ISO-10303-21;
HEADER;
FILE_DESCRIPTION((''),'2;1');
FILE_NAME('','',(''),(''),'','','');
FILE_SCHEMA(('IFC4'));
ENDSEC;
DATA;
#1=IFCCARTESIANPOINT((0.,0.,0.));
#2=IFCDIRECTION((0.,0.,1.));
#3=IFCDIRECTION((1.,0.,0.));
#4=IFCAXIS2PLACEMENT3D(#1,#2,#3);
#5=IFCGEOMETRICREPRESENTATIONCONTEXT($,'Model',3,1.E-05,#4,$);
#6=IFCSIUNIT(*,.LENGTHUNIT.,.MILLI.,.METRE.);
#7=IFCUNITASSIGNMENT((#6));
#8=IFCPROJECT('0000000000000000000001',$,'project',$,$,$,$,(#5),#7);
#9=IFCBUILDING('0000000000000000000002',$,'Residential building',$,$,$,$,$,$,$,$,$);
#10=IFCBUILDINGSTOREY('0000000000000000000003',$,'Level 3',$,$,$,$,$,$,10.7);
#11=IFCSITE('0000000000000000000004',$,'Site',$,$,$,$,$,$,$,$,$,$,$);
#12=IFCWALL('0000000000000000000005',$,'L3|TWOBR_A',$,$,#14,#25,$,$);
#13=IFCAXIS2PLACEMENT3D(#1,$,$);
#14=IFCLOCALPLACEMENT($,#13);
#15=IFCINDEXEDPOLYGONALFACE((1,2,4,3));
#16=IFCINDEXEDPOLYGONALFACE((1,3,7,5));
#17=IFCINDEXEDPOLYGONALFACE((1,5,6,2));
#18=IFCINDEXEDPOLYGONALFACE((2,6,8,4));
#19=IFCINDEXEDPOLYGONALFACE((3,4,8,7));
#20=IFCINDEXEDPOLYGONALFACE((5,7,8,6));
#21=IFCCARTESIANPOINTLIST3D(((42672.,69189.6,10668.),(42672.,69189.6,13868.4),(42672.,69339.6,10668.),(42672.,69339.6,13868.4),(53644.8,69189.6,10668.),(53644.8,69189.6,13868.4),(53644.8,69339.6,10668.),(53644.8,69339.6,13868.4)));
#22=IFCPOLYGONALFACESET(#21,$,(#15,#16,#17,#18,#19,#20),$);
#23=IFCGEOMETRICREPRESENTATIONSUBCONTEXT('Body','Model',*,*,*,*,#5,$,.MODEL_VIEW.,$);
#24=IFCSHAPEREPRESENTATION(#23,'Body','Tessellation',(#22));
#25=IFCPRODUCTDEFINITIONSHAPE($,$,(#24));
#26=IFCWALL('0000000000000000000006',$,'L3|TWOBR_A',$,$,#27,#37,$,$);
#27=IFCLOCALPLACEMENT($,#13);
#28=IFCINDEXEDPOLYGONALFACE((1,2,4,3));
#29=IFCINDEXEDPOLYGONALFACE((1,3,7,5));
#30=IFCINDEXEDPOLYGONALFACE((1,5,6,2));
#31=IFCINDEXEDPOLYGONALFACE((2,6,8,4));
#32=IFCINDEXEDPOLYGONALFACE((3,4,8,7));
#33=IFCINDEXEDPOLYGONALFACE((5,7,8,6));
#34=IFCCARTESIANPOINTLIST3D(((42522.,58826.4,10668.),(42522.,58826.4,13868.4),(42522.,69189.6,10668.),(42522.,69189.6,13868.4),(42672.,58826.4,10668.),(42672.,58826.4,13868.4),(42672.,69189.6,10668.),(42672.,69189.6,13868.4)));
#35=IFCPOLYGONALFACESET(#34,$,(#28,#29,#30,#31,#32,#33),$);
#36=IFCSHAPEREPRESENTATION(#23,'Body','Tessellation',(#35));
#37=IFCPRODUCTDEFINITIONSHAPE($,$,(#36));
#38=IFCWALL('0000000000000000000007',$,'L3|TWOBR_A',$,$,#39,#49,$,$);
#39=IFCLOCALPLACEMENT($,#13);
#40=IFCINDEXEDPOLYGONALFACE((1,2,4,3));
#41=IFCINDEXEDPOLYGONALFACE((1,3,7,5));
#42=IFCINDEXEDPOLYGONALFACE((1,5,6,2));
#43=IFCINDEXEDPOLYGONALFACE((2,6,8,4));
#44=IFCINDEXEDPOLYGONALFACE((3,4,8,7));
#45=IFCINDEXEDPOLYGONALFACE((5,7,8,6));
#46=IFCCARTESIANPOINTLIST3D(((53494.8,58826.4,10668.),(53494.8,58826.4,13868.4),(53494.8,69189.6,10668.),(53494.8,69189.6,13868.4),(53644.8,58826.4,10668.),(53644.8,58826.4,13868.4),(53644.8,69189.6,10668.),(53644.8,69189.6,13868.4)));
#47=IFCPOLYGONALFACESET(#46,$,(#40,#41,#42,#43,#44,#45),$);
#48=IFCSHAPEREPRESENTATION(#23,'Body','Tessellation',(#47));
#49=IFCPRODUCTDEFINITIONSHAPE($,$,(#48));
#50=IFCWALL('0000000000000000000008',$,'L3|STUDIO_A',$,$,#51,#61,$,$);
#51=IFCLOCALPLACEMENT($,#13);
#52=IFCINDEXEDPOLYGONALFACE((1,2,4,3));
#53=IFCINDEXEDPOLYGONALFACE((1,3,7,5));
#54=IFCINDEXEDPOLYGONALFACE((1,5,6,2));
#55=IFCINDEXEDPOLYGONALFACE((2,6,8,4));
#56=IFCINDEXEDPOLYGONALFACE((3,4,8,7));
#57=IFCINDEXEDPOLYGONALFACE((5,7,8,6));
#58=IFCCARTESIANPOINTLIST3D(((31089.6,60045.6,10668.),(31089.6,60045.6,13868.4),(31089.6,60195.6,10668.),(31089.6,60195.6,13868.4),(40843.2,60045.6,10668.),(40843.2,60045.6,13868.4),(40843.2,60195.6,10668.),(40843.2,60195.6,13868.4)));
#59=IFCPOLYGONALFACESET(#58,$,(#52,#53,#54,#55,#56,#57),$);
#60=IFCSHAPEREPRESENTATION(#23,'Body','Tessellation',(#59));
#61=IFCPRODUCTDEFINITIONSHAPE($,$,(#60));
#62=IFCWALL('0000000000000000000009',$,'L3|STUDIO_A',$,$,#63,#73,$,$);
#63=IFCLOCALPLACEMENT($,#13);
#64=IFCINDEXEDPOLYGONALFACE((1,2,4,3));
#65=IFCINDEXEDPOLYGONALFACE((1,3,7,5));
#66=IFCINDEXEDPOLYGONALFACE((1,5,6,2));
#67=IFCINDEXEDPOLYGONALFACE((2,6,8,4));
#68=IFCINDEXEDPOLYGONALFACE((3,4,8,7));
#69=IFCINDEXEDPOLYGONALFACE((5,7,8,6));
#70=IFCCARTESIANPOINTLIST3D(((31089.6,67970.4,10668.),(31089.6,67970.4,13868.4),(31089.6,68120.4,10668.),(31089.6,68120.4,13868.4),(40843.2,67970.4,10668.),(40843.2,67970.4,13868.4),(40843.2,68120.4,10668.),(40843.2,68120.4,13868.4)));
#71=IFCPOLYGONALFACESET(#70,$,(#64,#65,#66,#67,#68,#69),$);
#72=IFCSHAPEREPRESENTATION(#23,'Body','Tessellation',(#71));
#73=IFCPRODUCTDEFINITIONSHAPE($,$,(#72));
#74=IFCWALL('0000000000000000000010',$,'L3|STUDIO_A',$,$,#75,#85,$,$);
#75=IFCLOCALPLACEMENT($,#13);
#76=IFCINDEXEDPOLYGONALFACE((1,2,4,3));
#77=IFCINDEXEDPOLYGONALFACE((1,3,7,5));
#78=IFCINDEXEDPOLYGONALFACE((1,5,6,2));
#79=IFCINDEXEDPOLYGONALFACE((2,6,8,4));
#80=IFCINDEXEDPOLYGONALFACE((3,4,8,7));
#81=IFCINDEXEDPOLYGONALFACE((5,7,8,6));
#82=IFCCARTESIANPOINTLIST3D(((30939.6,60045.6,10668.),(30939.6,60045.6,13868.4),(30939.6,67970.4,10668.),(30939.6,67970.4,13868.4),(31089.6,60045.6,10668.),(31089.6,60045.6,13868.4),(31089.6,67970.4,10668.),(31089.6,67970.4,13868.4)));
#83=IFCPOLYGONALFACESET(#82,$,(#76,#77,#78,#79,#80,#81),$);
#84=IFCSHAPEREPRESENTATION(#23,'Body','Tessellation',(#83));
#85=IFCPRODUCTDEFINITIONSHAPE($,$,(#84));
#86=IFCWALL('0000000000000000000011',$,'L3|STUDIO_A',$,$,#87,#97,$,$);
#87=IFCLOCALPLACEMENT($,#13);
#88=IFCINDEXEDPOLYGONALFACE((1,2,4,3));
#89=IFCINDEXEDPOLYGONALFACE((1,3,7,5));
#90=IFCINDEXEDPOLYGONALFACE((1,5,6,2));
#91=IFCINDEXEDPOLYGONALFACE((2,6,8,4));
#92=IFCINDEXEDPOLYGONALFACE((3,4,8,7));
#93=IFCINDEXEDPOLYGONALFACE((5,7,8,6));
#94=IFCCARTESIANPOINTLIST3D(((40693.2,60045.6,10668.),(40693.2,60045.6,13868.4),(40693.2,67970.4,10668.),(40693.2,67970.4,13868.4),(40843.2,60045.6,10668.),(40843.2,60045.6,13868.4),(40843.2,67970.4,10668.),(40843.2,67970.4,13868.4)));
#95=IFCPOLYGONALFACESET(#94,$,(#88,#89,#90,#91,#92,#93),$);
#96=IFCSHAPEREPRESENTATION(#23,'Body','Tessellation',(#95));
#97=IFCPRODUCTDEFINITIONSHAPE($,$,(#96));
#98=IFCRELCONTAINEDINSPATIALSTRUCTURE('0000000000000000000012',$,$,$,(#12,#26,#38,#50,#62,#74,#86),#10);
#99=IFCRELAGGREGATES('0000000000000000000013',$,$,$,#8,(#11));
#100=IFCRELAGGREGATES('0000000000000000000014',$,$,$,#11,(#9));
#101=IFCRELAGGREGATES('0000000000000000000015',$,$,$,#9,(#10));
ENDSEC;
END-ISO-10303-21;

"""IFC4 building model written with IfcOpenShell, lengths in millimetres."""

from ifc_helpers import new_model, si_unit, frame, origin_with_axes, place, context, subcontext, project, spatial, indexed_curve, outline, extrude, element, save


model = new_model("IFC4")

# Units and contexts
model_context = context("Model", 3, precision=1e-05, world=origin_with_axes())
body_context = subcontext(model_context, "Body", "Model", "MODEL_VIEW")
ifc_project = project(units=[si_unit("LENGTHUNIT", "METRE", prefix="MILLI")], contexts=[model_context])

# Site, building, storey
site = spatial("IfcSite", under=ifc_project, Name="Site")
building = spatial("IfcBuilding", under=site, Name="Residential building")
storey = spatial("IfcBuildingStorey", under=building, Name="Level 3", Elevation=10.7)

# Walls
for number, where, z_axis, x_axis, name in (
    (1, (42672.0, 69189.6, 10668.0), (0.0, 0.0, 1.0), (1.0, 0.0, 0.0), "L3|TWOBR_A"),
):
    element("IfcWall", number, at=place(None, frame(where, z_axis=z_axis, x_axis=x_axis)), inside=storey, Name=name, context=body_context, shape_type="SweptSolid", body=[
        extrude(outline(indexed_curve([(0.0, 0.0), (0.0, 150.0), (10972.8, 150.0), (10972.8, 0.0), (0.0, 0.0)], self_intersect=False)), origin_with_axes(), (0.0, 0.0, 1.0), 3200.4),
    ])
for number, where, z_axis, x_axis, name in (
    (2, (42672.0, 58826.4, 10668.0), (0.0, 0.0, 1.0), (0.0, 1.0, 0.0), "L3|TWOBR_A"),
    (3, (53644.8, 58826.4, 10668.0), (0.0, 0.0, 1.0), (0.0, 1.0, 0.0), "L3|TWOBR_A"),
):
    element("IfcWall", number, at=place(None, frame(where, z_axis=z_axis, x_axis=x_axis)), inside=storey, Name=name, context=body_context, shape_type="SweptSolid", body=[
        extrude(outline(indexed_curve([(0.0, 0.0), (0.0, 150.0), (10363.2, 150.0), (10363.2, 0.0), (0.0, 0.0)], self_intersect=False)), origin_with_axes(), (0.0, 0.0, 1.0), 3200.4),
    ])
for number, where, z_axis, x_axis, name in (
    (4, (31089.6, 60045.6, 10668.0), (0.0, 0.0, 1.0), (1.0, 0.0, 0.0), "L3|STUDIO_A"),
    (5, (31089.6, 67970.4, 10668.0), (0.0, 0.0, 1.0), (1.0, 0.0, 0.0), "L3|STUDIO_A"),
):
    element("IfcWall", number, at=place(None, frame(where, z_axis=z_axis, x_axis=x_axis)), inside=storey, Name=name, context=body_context, shape_type="SweptSolid", body=[
        extrude(outline(indexed_curve([(0.0, 0.0), (0.0, 150.0), (9753.6, 150.0), (9753.6, 0.0), (0.0, 0.0)], self_intersect=False)), origin_with_axes(), (0.0, 0.0, 1.0), 3200.4),
    ])
for number, where, z_axis, x_axis, name in (
    (6, (31089.6, 60045.6, 10668.0), (0.0, 0.0, 1.0), (0.0, 1.0, 0.0), "L3|STUDIO_A"),
    (7, (40843.2, 60045.6, 10668.0), (0.0, 0.0, 1.0), (0.0, 1.0, 0.0), "L3|STUDIO_A"),
):
    element("IfcWall", number, at=place(None, frame(where, z_axis=z_axis, x_axis=x_axis)), inside=storey, Name=name, context=body_context, shape_type="SweptSolid", body=[
        extrude(outline(indexed_curve([(0.0, 0.0), (0.0, 150.0), (7924.8, 150.0), (7924.8, 0.0), (0.0, 0.0)], self_intersect=False)), origin_with_axes(), (0.0, 0.0, 1.0), 3200.4),
    ])

save(model, "model.ifc")
